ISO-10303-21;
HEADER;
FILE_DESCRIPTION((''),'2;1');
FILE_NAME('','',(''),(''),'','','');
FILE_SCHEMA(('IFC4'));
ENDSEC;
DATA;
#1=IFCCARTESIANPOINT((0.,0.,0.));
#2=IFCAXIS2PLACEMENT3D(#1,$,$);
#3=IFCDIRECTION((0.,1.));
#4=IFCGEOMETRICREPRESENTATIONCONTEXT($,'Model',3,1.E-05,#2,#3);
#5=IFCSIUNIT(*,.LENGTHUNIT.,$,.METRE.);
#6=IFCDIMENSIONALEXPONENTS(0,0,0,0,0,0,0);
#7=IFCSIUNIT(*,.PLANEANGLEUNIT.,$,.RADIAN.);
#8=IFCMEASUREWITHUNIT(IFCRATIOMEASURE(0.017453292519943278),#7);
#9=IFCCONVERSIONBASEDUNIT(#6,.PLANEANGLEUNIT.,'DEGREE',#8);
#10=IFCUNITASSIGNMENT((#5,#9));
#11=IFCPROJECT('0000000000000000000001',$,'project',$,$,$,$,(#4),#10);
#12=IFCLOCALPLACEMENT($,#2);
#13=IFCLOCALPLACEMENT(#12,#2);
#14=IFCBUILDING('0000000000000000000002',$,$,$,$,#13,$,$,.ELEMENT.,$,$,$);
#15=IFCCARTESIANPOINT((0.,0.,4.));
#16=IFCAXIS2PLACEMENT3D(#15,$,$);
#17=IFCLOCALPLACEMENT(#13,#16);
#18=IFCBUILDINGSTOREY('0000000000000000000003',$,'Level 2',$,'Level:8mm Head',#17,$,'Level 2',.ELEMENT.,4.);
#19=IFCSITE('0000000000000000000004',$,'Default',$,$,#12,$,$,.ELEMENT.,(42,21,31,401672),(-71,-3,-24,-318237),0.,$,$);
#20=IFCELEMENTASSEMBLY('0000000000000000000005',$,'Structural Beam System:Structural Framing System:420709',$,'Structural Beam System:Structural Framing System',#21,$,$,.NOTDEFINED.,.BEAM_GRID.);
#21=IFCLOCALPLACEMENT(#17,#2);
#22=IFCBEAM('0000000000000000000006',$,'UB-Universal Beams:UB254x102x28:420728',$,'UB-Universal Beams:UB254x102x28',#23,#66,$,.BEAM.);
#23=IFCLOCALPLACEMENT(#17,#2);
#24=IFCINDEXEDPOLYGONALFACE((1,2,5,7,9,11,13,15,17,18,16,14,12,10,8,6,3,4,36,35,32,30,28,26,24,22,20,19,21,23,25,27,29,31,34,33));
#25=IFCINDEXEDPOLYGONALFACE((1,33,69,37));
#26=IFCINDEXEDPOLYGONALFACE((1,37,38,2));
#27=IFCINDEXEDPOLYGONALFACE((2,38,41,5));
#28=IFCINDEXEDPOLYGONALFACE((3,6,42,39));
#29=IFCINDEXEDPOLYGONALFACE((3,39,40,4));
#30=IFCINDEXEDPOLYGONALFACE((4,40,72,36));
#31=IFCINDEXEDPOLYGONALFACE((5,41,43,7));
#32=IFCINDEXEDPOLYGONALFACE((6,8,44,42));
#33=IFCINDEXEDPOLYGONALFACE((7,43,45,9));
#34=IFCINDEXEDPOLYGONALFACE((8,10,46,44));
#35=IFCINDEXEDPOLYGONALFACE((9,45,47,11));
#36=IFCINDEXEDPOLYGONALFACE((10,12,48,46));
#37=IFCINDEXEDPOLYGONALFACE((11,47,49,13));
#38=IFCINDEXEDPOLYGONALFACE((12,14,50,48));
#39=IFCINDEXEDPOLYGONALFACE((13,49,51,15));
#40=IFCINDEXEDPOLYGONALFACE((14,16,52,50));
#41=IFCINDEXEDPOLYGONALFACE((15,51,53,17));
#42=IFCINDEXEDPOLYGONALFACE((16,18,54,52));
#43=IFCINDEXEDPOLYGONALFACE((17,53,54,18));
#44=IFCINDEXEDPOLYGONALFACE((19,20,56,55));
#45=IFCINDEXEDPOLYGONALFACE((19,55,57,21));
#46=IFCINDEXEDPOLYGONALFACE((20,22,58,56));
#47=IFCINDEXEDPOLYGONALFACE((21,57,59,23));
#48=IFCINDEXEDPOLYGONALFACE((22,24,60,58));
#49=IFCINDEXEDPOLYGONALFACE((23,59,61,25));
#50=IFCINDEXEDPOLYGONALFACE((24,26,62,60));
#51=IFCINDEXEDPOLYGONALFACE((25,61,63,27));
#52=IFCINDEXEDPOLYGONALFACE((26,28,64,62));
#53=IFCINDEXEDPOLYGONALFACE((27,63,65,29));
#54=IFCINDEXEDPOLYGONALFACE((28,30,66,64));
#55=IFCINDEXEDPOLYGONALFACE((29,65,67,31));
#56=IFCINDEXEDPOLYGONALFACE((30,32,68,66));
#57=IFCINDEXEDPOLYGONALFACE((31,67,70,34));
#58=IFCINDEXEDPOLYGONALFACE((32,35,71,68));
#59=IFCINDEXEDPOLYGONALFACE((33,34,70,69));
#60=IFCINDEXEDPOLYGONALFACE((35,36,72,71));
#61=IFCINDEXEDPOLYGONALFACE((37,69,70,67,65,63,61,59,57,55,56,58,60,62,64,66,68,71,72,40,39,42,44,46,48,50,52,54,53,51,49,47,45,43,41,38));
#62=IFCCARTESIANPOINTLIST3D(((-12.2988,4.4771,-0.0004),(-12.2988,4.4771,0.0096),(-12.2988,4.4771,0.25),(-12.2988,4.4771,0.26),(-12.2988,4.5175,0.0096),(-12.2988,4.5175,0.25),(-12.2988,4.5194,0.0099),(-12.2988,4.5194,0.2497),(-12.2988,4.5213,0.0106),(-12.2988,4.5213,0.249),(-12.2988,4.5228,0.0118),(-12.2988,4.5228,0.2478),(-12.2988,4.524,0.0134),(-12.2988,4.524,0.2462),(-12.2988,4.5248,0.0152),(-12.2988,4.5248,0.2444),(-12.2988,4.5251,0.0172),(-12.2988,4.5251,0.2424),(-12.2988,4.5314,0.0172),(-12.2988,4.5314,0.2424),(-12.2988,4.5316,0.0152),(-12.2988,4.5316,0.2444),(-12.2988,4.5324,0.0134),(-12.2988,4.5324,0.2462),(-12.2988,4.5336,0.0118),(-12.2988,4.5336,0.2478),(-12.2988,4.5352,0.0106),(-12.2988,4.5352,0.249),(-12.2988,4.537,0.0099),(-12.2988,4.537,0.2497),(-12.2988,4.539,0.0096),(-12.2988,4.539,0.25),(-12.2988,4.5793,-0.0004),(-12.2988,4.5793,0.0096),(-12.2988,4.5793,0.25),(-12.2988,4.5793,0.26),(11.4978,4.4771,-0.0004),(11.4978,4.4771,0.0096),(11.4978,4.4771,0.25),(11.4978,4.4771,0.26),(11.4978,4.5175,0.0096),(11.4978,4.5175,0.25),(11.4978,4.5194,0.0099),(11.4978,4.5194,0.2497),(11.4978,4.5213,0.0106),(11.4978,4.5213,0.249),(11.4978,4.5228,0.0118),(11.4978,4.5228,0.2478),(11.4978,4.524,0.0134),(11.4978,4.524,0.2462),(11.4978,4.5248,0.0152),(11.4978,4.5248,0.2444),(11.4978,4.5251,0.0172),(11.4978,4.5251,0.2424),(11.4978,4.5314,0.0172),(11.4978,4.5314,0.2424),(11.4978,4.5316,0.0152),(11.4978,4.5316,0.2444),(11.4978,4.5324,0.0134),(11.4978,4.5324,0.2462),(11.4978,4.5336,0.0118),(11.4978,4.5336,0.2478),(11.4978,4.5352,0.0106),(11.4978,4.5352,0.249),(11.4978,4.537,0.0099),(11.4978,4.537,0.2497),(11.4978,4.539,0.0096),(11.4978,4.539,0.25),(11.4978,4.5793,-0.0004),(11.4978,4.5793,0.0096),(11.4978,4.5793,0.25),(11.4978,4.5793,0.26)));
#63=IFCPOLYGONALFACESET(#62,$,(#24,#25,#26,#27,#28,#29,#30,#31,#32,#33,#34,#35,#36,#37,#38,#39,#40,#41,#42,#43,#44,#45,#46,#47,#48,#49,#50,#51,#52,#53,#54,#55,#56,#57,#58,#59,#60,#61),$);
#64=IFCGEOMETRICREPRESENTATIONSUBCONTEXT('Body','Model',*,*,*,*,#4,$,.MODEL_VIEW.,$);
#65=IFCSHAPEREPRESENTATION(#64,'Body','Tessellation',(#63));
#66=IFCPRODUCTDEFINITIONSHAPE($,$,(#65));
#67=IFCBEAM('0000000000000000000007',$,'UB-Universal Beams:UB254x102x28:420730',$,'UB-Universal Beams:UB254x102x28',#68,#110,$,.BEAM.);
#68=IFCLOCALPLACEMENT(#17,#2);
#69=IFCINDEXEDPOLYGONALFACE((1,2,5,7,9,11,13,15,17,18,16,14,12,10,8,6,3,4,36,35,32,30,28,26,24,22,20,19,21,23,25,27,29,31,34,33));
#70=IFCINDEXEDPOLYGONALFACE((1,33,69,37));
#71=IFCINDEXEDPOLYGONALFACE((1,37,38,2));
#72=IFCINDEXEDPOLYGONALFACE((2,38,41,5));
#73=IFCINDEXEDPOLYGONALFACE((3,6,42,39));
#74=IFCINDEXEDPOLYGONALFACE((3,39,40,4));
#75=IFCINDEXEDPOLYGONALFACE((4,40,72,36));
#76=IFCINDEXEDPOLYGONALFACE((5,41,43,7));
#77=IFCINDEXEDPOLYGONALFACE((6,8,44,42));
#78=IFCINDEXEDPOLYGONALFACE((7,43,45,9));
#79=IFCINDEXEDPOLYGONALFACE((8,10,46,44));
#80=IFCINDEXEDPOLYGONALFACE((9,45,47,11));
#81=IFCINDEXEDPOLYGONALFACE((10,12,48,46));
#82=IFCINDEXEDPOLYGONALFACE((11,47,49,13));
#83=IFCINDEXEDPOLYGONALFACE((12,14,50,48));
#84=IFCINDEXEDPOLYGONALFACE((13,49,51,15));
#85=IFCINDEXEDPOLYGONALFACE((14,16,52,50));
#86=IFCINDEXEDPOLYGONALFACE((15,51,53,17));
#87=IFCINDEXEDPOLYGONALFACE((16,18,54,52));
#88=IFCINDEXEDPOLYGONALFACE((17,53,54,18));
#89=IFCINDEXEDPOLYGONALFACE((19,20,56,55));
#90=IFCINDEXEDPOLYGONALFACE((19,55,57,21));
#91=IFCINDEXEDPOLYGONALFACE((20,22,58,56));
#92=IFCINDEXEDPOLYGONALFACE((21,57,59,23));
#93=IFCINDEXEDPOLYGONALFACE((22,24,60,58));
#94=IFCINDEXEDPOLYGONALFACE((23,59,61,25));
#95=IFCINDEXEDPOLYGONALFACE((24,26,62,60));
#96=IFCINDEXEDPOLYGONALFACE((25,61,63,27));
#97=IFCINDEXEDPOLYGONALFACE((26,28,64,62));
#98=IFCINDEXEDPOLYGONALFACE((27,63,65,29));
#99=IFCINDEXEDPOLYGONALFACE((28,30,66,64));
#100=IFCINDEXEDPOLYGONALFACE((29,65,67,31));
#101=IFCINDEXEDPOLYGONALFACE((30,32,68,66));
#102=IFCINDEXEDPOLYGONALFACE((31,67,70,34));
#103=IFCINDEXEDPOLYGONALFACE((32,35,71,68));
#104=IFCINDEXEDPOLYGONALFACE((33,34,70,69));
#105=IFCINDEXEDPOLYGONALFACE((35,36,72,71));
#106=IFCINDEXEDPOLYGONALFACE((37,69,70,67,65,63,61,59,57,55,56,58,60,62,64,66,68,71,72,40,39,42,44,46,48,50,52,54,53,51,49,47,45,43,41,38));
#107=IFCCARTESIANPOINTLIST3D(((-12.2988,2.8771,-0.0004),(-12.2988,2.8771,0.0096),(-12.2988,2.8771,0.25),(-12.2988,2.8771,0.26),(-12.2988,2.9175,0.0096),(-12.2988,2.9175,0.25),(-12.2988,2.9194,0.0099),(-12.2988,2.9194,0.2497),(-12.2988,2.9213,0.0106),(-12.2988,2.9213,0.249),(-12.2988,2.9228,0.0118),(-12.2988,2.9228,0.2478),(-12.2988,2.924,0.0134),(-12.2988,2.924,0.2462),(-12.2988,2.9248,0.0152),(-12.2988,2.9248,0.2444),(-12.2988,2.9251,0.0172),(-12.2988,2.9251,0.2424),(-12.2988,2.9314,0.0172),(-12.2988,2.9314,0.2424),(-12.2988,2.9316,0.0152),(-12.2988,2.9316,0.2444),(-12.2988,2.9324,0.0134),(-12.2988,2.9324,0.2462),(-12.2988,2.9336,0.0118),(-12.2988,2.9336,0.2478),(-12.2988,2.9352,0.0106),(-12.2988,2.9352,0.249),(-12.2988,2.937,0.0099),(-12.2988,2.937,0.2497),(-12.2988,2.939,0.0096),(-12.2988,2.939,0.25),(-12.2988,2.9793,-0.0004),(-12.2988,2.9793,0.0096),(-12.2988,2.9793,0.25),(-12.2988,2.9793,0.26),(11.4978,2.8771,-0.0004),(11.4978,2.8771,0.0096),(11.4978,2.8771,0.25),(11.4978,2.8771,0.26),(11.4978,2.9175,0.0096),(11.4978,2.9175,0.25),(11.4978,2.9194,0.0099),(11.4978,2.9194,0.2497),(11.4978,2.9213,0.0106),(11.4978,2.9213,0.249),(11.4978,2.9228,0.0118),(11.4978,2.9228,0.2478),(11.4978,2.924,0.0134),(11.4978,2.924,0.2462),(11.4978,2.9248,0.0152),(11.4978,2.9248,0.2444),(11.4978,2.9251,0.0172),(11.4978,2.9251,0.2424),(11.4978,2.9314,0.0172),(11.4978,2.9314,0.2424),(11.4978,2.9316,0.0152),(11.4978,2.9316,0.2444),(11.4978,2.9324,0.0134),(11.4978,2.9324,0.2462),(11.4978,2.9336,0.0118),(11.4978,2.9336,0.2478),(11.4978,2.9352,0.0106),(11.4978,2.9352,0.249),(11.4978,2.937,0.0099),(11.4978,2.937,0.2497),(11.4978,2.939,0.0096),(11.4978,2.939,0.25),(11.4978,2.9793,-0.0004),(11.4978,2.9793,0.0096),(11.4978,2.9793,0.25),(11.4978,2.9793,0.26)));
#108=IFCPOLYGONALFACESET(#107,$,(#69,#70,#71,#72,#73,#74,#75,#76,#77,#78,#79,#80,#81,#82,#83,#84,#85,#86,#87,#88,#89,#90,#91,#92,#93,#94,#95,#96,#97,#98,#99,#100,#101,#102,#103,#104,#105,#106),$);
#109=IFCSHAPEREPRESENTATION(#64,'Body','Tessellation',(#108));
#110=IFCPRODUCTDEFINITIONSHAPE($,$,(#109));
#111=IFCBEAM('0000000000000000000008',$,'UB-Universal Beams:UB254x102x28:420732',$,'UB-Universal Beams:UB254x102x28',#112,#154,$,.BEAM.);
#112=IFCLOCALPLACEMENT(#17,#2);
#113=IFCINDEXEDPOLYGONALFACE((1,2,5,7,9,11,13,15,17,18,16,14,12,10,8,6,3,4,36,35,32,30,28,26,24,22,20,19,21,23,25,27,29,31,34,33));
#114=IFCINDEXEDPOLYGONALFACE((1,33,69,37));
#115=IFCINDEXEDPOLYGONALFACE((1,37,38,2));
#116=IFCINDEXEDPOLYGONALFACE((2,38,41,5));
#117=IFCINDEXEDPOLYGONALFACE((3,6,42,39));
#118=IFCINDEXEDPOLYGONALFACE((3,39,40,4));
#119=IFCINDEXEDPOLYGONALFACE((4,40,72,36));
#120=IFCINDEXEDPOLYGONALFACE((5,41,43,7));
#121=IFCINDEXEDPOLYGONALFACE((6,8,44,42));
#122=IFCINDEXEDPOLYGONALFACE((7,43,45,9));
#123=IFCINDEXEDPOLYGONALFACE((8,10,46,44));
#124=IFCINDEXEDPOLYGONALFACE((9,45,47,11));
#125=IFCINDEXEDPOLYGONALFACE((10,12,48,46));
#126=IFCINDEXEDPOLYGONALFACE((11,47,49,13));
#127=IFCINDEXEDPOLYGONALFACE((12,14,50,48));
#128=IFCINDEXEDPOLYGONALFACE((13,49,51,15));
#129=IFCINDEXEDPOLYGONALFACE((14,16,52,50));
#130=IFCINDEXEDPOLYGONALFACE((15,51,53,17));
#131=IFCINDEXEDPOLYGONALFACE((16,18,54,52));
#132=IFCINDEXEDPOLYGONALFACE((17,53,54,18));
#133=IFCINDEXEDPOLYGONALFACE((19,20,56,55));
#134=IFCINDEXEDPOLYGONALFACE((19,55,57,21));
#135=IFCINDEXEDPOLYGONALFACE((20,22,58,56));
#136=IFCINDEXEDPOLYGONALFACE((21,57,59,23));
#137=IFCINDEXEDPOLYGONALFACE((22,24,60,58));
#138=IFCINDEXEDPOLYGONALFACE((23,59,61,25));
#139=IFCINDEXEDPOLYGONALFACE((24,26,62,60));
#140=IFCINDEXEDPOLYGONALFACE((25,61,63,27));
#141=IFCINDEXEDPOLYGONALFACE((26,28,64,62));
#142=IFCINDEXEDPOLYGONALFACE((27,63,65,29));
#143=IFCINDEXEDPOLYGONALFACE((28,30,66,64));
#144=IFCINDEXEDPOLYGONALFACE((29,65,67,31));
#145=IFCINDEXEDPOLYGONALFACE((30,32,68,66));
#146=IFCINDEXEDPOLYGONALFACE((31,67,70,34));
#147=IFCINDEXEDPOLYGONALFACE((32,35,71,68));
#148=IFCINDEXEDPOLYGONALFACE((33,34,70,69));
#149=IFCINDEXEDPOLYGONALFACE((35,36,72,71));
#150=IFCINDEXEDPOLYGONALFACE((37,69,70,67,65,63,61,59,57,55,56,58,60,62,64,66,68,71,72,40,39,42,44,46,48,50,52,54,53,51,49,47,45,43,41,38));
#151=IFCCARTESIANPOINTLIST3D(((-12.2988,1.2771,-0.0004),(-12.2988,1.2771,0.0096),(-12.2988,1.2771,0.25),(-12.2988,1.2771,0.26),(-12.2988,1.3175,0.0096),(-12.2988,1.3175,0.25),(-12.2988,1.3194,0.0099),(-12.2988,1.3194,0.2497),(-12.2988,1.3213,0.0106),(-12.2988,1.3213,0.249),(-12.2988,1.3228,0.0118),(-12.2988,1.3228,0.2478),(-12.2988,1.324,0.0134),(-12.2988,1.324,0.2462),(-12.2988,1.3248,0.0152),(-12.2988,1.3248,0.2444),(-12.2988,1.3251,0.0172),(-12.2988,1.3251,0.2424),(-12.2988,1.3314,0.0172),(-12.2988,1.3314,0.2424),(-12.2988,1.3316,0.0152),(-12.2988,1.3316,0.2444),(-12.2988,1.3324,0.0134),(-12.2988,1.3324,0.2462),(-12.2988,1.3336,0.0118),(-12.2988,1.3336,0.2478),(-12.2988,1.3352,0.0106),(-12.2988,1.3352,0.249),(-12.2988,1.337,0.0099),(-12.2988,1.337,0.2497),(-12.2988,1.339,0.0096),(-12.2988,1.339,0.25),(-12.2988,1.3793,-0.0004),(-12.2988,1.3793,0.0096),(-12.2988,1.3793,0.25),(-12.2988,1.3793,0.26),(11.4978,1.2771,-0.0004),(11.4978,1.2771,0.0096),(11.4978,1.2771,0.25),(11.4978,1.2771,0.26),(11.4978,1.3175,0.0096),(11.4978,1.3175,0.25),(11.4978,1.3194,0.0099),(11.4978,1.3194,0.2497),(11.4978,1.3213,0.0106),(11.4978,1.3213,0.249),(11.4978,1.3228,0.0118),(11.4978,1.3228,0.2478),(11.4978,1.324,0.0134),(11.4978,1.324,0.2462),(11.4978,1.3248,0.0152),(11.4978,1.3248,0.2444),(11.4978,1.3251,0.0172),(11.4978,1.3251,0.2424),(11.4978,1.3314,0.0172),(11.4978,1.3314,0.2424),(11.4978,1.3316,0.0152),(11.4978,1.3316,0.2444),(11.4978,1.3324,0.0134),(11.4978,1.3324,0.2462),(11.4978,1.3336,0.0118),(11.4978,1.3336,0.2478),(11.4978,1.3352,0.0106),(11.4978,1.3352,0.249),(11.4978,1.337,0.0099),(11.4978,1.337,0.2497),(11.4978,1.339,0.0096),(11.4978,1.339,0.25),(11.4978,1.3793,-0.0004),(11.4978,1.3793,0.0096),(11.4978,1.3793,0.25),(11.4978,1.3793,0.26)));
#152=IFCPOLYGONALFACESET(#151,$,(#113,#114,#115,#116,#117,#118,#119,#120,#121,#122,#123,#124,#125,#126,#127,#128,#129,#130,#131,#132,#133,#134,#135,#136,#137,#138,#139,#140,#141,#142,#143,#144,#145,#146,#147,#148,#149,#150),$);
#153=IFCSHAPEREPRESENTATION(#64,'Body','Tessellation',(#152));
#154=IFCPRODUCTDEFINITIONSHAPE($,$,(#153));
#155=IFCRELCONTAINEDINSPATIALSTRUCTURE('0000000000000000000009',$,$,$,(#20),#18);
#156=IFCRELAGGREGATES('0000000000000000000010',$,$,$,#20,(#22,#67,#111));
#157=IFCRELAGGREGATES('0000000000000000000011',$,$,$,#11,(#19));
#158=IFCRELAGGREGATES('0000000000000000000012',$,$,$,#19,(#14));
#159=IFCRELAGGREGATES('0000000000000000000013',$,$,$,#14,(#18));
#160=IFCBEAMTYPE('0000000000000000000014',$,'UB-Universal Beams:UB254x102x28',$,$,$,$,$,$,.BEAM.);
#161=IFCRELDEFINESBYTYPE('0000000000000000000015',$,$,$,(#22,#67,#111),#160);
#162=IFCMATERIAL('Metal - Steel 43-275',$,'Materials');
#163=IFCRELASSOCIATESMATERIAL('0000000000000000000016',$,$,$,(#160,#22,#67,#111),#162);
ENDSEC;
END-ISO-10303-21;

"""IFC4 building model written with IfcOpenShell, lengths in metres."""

from ifc_helpers import new_model, entity, si_unit, converted_unit, direction, frame, origin, place, context, subcontext, project, spatial, line, arc, indexed_curve, outline, extrude, source, transform, mapped, material, type_object, type_shapes, element, aggregate, save


model = new_model("IFC4")

# Units and contexts
model_context = context("Model", 3, precision=1e-05, world=origin(), true_north=direction((0.0, 1.0)))
body_context = subcontext(model_context, "Body", "Model", "MODEL_VIEW")
ifc_project = project(units=[si_unit("LENGTHUNIT", "METRE"), converted_unit("PLANEANGLEUNIT", "DEGREE", entity("IfcRatioMeasure", 0.017453292519943278), si_unit("PLANEANGLEUNIT", "RADIAN"), dimensions=[0, 0, 0, 0, 0, 0, 0])], contexts=[model_context])

# Site, building, storey
site_placement = place(None, origin())
site = spatial("IfcSite", under=ifc_project, at=site_placement, Name="Default", CompositionType="ELEMENT", RefLatitude=(42, 21, 31, 401672), RefLongitude=(-71, -3, -24, -318237), RefElevation=0.0)
building_placement = place(site_placement, origin())
building = spatial("IfcBuilding", under=site, at=building_placement, CompositionType="ELEMENT")
storey_placement = place(building_placement, frame((0.0, 0.0, 4.0)))
storey = spatial("IfcBuildingStorey", under=building, at=storey_placement, Name="Level 2", ObjectType="Level:8mm Head", LongName="Level 2", CompositionType="ELEMENT", Elevation=4.0)

# Shared definitions
ifc_material_1 = material(Name="Metal - Steel 43-275", Category="Materials")

# Element assembly, beams
assembly_placement = place(storey_placement, origin())
assembly = element("IfcElementAssembly", 1, at=assembly_placement, inside=storey, Name="Structural Beam System:Structural Framing System:420709", ObjectType="Structural Beam System:Structural Framing System", AssemblyPlace="NOTDEFINED", PredefinedType="BEAM_GRID")
beam_type_1 = type_object("IfcBeamType", Name="UB-Universal Beams:UB254x102x28", PredefinedType="BEAM", material=ifc_material_1)
shared_shape_1 = source(origin(), body_context, "Body", "SweptSolid", [
    extrude(outline(indexed_curve([(-0.1302, -0.0511), (-0.1202, -0.0511), (-0.1202, -0.0107), (-0.118, -0.0054), (-0.1126, -0.0031), (0.1126, -0.0031), (0.118, -0.0054), (0.1202, -0.0107), (0.1202, -0.0511), (0.1302, -0.0511), (0.1302, 0.0511), (0.1202, 0.0511), (0.1202, 0.0108), (0.118, 0.0054), (0.1126, 0.0032), (-0.1126, 0.0032), (-0.118, 0.0054), (-0.1202, 0.0108), (-0.1202, 0.0511), (-0.1302, 0.0511)], segments=[line(1, 2, 3), arc(3, 4, 5), line(5, 6), arc(6, 7, 8), line(8, 9, 10, 11, 12, 13), arc(13, 14, 15), line(15, 16), arc(16, 17, 18), line(18, 19, 20, 1)], self_intersect=False)), frame((-11.8983, 0.0, 0.0), z_axis=(1.0, 0.0, 0.0), x_axis=(0.0, 0.0, -1.0)), (0.0, 0.0, 1.0), 23.7966),
])
type_shapes(beam_type_1, [shared_shape_1])
beam_1_placement = place(assembly_placement, frame((-0.4005, 4.5282, 0.1298)))
beam_1 = element("IfcBeam", 2, at=beam_1_placement, type_object=beam_type_1, material=ifc_material_1, Name="UB-Universal Beams:UB254x102x28:420728", ObjectType="UB-Universal Beams:UB254x102x28", PredefinedType="BEAM", context=body_context, shape_type="MappedRepresentation", body=[
    mapped(shared_shape_1, transform((0.0, 0.0, 0.0), scale=1.0)),
])
beam_2_placement = place(assembly_placement, frame((-0.4005, 2.9282, 0.1298)))
beam_2 = element("IfcBeam", 3, at=beam_2_placement, type_object=beam_type_1, material=ifc_material_1, Name="UB-Universal Beams:UB254x102x28:420730", ObjectType="UB-Universal Beams:UB254x102x28", PredefinedType="BEAM", context=body_context, shape_type="MappedRepresentation", body=[
    mapped(shared_shape_1, transform((0.0, 0.0, 0.0), scale=1.0)),
])
beam_3_placement = place(assembly_placement, frame((-0.4005, 1.3282, 0.1298)))
beam_3 = element("IfcBeam", 4, at=beam_3_placement, type_object=beam_type_1, material=ifc_material_1, Name="UB-Universal Beams:UB254x102x28:420732", ObjectType="UB-Universal Beams:UB254x102x28", PredefinedType="BEAM", context=body_context, shape_type="MappedRepresentation", body=[
    mapped(shared_shape_1, transform((0.0, 0.0, 0.0), scale=1.0)),
])
aggregate(assembly, [beam_1, beam_2, beam_3])

save(model, "model.ifc")
